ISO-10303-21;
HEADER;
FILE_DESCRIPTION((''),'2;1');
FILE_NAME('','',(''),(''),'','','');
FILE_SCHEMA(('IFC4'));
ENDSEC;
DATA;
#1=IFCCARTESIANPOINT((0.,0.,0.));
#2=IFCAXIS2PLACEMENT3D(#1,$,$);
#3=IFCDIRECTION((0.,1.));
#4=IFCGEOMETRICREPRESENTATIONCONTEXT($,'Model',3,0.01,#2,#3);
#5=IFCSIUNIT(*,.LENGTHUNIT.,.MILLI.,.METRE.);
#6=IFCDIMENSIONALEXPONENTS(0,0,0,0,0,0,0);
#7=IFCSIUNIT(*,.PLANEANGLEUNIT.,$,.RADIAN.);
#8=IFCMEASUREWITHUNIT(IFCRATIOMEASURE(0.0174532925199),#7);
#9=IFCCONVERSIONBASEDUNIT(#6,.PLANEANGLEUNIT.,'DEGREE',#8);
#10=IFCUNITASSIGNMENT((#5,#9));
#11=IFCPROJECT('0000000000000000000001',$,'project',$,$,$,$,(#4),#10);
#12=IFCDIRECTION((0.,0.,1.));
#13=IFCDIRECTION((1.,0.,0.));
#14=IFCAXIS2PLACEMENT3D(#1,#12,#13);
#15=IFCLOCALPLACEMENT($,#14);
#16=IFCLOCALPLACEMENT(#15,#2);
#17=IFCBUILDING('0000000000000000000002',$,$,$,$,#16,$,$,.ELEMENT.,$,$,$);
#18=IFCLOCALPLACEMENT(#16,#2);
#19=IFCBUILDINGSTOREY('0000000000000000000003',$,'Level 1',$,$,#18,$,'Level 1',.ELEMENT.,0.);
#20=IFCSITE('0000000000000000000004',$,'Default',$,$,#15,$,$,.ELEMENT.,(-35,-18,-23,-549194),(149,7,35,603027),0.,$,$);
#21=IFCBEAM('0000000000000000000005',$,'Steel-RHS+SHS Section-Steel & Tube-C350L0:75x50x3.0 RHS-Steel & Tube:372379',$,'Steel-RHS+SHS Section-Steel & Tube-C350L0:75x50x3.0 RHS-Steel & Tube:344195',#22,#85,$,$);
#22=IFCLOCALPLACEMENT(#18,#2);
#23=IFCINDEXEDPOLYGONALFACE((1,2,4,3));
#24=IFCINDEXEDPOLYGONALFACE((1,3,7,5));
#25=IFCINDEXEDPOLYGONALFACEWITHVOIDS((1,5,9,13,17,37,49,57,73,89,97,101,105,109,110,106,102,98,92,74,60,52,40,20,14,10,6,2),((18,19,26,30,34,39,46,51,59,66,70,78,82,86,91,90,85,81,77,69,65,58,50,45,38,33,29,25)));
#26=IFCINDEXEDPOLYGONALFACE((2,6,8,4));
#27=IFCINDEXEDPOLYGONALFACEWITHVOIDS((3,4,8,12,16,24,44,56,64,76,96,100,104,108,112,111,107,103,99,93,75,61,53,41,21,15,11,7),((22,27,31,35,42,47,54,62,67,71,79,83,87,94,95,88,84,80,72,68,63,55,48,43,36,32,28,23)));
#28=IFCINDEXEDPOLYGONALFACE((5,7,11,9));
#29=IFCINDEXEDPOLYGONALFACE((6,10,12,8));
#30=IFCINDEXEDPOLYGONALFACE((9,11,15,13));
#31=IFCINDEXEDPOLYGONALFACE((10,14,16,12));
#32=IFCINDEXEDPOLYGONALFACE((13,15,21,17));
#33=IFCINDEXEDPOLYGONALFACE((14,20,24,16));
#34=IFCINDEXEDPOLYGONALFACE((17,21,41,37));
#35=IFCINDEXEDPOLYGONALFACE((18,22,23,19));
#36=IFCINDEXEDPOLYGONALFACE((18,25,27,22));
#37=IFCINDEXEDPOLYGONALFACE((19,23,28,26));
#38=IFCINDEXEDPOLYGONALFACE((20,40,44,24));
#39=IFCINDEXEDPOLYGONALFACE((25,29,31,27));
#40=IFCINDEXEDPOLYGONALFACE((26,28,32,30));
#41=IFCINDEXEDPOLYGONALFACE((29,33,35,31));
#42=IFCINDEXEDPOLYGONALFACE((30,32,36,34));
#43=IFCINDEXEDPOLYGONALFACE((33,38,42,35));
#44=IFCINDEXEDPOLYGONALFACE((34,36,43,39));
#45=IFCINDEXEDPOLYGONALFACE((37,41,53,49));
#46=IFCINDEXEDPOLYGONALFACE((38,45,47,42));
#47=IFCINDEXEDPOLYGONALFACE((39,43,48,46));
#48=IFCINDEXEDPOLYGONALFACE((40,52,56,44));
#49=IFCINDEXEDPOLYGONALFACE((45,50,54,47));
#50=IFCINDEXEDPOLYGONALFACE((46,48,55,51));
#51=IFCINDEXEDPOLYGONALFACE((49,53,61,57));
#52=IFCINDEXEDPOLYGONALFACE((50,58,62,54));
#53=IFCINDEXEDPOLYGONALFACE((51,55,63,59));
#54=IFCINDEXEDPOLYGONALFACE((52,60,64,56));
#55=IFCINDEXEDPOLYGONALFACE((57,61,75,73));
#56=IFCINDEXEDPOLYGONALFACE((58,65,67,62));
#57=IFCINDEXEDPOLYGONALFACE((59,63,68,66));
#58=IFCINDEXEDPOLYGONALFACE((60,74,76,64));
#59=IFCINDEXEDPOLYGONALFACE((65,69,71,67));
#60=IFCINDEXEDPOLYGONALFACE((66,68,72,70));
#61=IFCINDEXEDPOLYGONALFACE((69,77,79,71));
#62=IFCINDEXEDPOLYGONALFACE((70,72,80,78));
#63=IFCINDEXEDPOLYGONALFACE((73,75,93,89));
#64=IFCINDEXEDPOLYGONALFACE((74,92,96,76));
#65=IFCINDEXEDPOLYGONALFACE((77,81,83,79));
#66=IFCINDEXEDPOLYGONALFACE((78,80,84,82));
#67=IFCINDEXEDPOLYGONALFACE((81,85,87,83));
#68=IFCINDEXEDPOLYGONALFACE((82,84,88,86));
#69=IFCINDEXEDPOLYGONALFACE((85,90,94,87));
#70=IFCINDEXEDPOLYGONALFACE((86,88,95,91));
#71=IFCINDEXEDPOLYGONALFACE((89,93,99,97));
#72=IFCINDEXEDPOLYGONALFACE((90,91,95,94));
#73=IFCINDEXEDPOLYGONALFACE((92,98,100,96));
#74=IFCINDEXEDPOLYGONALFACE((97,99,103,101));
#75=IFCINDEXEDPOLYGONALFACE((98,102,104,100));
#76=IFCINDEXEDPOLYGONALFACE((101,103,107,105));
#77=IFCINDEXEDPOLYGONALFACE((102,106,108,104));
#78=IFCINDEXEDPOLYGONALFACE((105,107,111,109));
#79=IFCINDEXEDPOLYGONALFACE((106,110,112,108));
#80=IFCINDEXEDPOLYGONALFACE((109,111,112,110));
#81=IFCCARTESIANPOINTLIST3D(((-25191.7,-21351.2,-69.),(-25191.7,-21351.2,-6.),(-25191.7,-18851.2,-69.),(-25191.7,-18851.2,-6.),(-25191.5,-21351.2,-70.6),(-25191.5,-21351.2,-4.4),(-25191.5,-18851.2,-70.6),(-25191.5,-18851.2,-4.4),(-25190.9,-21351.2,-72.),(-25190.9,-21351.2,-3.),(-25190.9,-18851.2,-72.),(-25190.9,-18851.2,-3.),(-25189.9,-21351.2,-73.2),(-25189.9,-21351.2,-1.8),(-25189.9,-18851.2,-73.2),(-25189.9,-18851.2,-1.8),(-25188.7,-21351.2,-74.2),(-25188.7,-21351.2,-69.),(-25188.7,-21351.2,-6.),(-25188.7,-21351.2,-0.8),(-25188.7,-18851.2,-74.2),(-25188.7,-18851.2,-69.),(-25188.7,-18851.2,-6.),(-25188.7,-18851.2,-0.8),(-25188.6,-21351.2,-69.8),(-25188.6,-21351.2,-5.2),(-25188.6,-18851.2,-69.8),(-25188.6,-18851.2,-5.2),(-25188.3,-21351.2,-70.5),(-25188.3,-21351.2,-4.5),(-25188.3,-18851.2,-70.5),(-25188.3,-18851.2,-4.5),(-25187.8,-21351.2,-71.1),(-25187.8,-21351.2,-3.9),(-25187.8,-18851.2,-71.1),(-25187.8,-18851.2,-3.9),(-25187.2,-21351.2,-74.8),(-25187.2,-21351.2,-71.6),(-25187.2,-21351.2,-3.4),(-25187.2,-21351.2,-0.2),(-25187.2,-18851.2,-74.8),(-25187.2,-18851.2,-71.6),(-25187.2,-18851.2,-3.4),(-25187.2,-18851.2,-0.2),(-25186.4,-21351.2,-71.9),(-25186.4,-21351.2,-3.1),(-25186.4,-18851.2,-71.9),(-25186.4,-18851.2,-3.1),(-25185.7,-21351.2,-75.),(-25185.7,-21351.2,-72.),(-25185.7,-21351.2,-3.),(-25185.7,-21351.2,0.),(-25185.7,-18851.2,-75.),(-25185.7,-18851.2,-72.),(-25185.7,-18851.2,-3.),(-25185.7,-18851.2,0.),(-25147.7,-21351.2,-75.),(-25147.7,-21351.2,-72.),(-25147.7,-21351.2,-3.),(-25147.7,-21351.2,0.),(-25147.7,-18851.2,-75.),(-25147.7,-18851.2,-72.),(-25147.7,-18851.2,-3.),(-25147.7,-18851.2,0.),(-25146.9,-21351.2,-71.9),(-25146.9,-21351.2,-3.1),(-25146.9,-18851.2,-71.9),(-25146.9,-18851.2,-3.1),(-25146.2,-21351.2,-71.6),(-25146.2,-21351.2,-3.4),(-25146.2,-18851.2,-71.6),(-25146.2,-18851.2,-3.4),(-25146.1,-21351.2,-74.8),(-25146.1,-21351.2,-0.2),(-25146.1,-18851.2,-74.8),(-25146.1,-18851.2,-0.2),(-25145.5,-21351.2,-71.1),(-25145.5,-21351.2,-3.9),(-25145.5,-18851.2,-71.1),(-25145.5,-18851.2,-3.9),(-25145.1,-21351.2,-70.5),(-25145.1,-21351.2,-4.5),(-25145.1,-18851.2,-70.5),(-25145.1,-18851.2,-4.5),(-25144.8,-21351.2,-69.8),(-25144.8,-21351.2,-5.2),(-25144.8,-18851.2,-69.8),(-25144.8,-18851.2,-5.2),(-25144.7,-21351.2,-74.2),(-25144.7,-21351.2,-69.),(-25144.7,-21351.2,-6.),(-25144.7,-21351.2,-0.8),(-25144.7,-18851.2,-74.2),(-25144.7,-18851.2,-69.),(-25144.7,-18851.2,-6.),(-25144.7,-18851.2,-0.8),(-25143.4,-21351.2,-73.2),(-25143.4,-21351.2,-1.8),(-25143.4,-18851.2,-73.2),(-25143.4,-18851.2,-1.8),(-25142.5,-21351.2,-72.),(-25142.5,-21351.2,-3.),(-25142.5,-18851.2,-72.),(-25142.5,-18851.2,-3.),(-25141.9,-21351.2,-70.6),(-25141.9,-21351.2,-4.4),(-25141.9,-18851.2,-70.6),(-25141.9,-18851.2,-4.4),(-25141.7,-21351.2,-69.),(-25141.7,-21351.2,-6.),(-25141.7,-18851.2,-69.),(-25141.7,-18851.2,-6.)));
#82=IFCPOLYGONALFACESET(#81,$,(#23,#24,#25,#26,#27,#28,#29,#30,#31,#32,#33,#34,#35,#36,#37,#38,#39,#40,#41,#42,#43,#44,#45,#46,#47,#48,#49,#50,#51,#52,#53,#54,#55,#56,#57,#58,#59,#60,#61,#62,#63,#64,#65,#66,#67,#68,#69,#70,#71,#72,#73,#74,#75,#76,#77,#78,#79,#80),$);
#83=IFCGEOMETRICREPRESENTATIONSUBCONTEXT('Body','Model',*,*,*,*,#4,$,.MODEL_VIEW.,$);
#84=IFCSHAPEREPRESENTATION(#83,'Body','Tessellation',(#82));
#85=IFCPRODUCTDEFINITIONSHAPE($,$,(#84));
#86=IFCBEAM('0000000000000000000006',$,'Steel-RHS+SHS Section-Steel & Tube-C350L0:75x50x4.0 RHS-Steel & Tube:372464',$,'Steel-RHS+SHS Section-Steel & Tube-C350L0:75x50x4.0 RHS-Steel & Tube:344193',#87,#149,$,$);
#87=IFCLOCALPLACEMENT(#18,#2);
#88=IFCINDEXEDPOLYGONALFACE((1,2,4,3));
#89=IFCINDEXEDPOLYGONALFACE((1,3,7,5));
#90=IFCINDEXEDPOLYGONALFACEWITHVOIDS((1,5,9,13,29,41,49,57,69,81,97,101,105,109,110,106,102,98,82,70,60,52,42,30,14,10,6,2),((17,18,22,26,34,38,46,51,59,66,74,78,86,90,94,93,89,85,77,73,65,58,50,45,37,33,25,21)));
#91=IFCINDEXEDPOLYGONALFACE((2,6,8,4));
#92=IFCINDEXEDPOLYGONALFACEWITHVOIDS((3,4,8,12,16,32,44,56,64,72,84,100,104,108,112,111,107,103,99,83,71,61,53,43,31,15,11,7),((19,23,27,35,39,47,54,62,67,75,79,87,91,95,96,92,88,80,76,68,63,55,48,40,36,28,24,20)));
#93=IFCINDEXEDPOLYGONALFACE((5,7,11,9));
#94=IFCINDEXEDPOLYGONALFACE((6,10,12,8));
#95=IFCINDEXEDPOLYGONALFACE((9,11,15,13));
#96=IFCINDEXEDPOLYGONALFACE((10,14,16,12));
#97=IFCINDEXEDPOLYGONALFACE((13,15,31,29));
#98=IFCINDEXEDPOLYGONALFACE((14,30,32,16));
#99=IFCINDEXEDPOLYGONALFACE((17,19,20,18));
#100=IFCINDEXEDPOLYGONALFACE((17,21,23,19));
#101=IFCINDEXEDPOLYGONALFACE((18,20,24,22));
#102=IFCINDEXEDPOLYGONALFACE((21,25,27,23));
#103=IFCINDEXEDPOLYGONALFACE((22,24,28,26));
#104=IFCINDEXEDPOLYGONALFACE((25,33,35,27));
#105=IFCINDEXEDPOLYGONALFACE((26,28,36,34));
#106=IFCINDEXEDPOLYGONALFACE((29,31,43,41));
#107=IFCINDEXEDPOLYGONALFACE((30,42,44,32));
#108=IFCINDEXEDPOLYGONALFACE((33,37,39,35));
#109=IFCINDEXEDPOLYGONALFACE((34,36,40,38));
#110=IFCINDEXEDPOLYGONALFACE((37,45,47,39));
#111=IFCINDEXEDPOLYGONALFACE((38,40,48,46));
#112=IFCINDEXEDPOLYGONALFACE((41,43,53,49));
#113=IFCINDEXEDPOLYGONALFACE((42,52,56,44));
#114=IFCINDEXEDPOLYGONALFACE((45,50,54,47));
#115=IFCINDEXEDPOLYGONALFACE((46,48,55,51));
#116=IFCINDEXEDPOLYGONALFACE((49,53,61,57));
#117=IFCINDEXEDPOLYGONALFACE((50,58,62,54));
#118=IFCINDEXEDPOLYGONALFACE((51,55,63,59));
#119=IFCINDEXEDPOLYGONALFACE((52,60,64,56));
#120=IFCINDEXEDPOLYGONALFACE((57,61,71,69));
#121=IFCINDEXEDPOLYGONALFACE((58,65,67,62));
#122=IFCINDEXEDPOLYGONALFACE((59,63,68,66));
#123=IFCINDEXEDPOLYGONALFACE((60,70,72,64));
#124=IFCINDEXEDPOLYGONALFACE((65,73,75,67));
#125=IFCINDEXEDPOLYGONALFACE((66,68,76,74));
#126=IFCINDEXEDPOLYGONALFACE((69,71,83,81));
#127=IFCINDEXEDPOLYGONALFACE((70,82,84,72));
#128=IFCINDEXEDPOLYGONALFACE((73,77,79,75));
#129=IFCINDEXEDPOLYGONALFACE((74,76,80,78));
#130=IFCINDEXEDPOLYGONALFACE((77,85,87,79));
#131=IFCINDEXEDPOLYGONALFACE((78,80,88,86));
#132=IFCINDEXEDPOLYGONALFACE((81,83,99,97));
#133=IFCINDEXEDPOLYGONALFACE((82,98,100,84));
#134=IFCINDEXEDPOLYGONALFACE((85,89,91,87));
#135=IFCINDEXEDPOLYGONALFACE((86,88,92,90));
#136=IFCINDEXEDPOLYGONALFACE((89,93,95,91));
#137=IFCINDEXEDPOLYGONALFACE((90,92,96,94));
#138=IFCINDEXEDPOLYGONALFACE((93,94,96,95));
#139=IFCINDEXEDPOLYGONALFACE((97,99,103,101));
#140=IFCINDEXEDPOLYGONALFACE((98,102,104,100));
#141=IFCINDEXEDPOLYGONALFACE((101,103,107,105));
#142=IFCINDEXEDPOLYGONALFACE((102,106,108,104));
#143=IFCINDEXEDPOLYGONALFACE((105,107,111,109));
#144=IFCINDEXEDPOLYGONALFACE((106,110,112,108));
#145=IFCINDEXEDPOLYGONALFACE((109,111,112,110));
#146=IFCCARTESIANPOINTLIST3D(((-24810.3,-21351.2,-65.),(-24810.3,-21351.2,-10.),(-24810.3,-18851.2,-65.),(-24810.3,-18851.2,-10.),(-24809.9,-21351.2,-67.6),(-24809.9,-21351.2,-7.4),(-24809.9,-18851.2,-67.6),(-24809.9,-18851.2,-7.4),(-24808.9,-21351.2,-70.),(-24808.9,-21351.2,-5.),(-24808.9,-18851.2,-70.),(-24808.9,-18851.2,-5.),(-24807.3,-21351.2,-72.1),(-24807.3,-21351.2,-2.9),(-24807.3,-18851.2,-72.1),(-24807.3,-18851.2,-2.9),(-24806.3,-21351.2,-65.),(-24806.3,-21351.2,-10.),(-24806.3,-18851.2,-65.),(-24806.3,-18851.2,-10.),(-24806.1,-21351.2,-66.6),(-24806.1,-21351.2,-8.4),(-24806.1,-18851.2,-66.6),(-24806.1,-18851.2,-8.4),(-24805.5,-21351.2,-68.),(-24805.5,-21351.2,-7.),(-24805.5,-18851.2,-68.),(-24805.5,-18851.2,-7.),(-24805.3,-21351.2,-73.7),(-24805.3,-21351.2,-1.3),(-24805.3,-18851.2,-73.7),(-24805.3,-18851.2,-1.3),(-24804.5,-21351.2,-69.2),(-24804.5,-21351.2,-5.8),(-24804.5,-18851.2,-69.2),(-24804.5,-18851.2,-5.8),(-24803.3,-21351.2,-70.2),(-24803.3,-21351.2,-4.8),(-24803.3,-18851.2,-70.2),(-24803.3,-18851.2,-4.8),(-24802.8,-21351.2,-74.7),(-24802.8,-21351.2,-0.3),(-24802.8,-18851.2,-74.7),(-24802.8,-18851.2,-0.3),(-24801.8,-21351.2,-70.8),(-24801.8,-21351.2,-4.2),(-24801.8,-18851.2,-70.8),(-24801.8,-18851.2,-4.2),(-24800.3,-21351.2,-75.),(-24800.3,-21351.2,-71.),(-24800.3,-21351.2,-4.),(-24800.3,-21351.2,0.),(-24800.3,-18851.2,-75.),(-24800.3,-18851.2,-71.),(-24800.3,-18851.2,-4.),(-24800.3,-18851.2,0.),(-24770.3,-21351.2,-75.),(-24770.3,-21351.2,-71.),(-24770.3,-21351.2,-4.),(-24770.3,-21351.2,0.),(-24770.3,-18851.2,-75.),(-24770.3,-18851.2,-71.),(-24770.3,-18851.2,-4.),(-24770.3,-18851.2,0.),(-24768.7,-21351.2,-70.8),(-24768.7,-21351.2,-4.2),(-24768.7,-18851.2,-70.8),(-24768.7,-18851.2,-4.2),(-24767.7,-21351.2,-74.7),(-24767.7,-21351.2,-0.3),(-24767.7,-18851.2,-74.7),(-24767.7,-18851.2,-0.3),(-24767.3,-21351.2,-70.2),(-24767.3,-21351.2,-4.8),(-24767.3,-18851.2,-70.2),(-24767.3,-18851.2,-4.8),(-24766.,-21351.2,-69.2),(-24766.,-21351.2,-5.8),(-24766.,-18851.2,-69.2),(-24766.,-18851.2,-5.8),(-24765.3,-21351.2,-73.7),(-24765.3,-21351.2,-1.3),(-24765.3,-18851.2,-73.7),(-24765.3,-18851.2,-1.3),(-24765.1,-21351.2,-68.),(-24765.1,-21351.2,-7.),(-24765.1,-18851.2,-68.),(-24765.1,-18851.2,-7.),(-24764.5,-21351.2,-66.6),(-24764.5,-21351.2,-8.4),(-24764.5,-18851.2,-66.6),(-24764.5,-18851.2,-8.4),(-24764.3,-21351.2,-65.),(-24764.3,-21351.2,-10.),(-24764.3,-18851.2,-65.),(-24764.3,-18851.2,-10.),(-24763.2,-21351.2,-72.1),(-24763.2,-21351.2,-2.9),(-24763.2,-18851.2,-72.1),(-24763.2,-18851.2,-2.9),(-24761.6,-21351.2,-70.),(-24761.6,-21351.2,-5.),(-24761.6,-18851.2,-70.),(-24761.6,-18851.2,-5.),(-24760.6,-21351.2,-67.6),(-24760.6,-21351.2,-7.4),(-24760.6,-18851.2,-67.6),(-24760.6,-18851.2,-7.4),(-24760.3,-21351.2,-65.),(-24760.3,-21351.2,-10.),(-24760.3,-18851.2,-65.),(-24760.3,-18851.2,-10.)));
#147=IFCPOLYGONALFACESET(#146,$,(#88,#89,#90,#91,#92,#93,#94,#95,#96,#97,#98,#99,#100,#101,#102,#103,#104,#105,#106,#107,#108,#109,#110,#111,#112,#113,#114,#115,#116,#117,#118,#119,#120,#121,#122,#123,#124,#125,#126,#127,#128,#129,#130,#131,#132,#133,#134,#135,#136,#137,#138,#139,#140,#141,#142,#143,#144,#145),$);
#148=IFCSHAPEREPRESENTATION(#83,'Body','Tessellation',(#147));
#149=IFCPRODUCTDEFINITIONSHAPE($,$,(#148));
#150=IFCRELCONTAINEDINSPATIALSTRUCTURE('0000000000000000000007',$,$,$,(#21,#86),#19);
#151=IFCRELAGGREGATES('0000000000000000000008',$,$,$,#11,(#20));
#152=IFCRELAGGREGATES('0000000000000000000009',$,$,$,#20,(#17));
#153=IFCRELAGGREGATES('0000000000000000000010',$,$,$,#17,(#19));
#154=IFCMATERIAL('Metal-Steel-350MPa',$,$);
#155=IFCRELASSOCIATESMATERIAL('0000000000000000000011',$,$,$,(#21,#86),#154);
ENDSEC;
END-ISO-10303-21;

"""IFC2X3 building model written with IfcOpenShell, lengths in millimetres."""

from ifc_helpers import new_model, entity, si_unit, converted_unit, direction, frame, frame_2d, origin, origin_with_axes, place, context, subcontext, project, spatial, polyline, circle_curve, parameter, trimmed, segment, composite_curve, outline, extrude, material, element, save


model = new_model("IFC2X3")

# Units and contexts
model_context = context("Model", 3, precision=0.01, world=origin(), true_north=direction((0.0, 1.0)))
body_context = subcontext(model_context, "Body", "Model", "MODEL_VIEW")
ifc_project = project(units=[si_unit("LENGTHUNIT", "METRE", prefix="MILLI"), converted_unit("PLANEANGLEUNIT", "DEGREE", entity("IfcRatioMeasure", 0.0174532925199), si_unit("PLANEANGLEUNIT", "RADIAN"), dimensions=[0, 0, 0, 0, 0, 0, 0])], contexts=[model_context])

# Site, building, storey
site_placement = place(None, origin_with_axes())
site = spatial("IfcSite", under=ifc_project, at=site_placement, Name="Default", CompositionType="ELEMENT", RefLatitude=(-35, -18, -23, -549194), RefLongitude=(149, 7, 35, 603027), RefElevation=0.0)
building_placement = place(site_placement, origin())
building = spatial("IfcBuilding", under=site, at=building_placement, CompositionType="ELEMENT")
storey_placement = place(building_placement, origin())
storey = spatial("IfcBuildingStorey", under=building, at=storey_placement, Name="Level 1", LongName="Level 1", CompositionType="ELEMENT", Elevation=0.0)

# Beams
ifc_material = material(Name="Metal-Steel-350MPa")
beam_1_placement = place(storey_placement, frame((-25166.7, -18851.2, 0.0), z_axis=(0.0, 0.0, 1.0), x_axis=(0.0, -1.0, 0.0)))
element("IfcBeam", 1, at=beam_1_placement, inside=storey, material=ifc_material, Name="Steel-RHS+SHS Section-Steel & Tube-C350L0:75x50x3.0 RHS-Steel & Tube:372379", ObjectType="Steel-RHS+SHS Section-Steel & Tube-C350L0:75x50x3.0 RHS-Steel & Tube:344195", context=body_context, shape_type="SweptSolid", body=[
    extrude(outline(composite_curve([segment(trimmed(circle_curve(frame_2d((-19.0, -31.5), x_axis=(1.0, 0.0)), 6.0), [parameter(180.0)], [parameter(270.0)], True, "PARAMETER"), True, "CONTINUOUS"), segment(polyline([(-19.0, -37.5), (19.0, -37.5)]), True, "CONTINUOUS"), segment(trimmed(circle_curve(frame_2d((19.0, -31.5), x_axis=(1.0, 0.0)), 6.0), [parameter(270.0)], [parameter(0.0)], True, "PARAMETER"), True, "CONTINUOUS"), segment(polyline([(25.0, -31.5), (25.0, 31.5)]), True, "CONTINUOUS"), segment(trimmed(circle_curve(frame_2d((19.0, 31.5), x_axis=(1.0, 0.0)), 6.0), [parameter(0.0)], [parameter(90.0)], True, "PARAMETER"), True, "CONTINUOUS"), segment(polyline([(19.0, 37.5), (-19.0, 37.5)]), True, "CONTINUOUS"), segment(trimmed(circle_curve(frame_2d((-19.0, 31.5), x_axis=(1.0, 0.0)), 6.0), [parameter(90.0)], [parameter(180.0)], True, "PARAMETER"), True, "CONTINUOUS"), segment(polyline([(-25.0, 31.5), (-25.0, -31.5)]), True, "CONTINUOUS")], self_intersect=False), holes=[composite_curve([segment(polyline([(19.0, -34.5), (-19.0, -34.5)]), True, "CONTINUOUS"), segment(trimmed(circle_curve(frame_2d((-19.0, -31.5), x_axis=(1.0, 0.0)), 3.0), [parameter(180.0)], [parameter(270.0)], True, "PARAMETER"), False, "CONTINUOUS"), segment(polyline([(-22.0, -31.5), (-22.0, 31.5)]), True, "CONTINUOUS"), segment(trimmed(circle_curve(frame_2d((-19.0, 31.5), x_axis=(1.0, 0.0)), 3.0), [parameter(90.0)], [parameter(180.0)], True, "PARAMETER"), False, "CONTINUOUS"), segment(polyline([(-19.0, 34.5), (19.0, 34.5)]), True, "CONTINUOUS"), segment(trimmed(circle_curve(frame_2d((19.0, 31.5), x_axis=(1.0, 0.0)), 3.0), [parameter(360.0)], [parameter(90.0)], True, "PARAMETER"), False, "CONTINUOUS"), segment(polyline([(22.0, 31.5), (22.0, -31.5)]), True, "CONTINUOUS"), segment(trimmed(circle_curve(frame_2d((19.0, -31.5), x_axis=(1.0, 0.0)), 3.0), [parameter(270.0)], [parameter(0.0)], True, "PARAMETER"), False, "CONTINUOUS")], self_intersect=False)]), frame((0.0, 0.0, -37.5), z_axis=(1.0, 0.0, 0.0), x_axis=(0.0, -1.0, 0.0)), (0.0, 0.0, 1.0), 2500.0),
])
beam_2_placement = place(storey_placement, frame((-24785.3, -18851.2, 0.0), z_axis=(0.0, 0.0, 1.0), x_axis=(0.0, -1.0, 0.0)))
element("IfcBeam", 2, at=beam_2_placement, inside=storey, material=ifc_material, Name="Steel-RHS+SHS Section-Steel & Tube-C350L0:75x50x4.0 RHS-Steel & Tube:372464", ObjectType="Steel-RHS+SHS Section-Steel & Tube-C350L0:75x50x4.0 RHS-Steel & Tube:344193", context=body_context, shape_type="SweptSolid", body=[
    extrude(outline(composite_curve([segment(trimmed(circle_curve(frame_2d((-15.0, -27.5), x_axis=(1.0, 0.0)), 10.0), [parameter(180.0)], [parameter(270.0)], True, "PARAMETER"), True, "CONTINUOUS"), segment(polyline([(-15.0, -37.5), (15.0, -37.5)]), True, "CONTINUOUS"), segment(trimmed(circle_curve(frame_2d((15.0, -27.5), x_axis=(1.0, 0.0)), 10.0), [parameter(270.0)], [parameter(0.0)], True, "PARAMETER"), True, "CONTINUOUS"), segment(polyline([(25.0, -27.5), (25.0, 27.5)]), True, "CONTINUOUS"), segment(trimmed(circle_curve(frame_2d((15.0, 27.5), x_axis=(1.0, 0.0)), 10.0), [parameter(0.0)], [parameter(90.0)], True, "PARAMETER"), True, "CONTINUOUS"), segment(polyline([(15.0, 37.5), (-15.0, 37.5)]), True, "CONTINUOUS"), segment(trimmed(circle_curve(frame_2d((-15.0, 27.5), x_axis=(1.0, 0.0)), 10.0), [parameter(90.0)], [parameter(180.0)], True, "PARAMETER"), True, "CONTINUOUS"), segment(polyline([(-25.0, 27.5), (-25.0, -27.5)]), True, "CONTINUOUS")], self_intersect=False), holes=[composite_curve([segment(polyline([(15.0, -33.5), (-15.0, -33.5)]), True, "CONTINUOUS"), segment(trimmed(circle_curve(frame_2d((-15.0, -27.5), x_axis=(1.0, 0.0)), 6.0), [parameter(180.0)], [parameter(270.0)], True, "PARAMETER"), False, "CONTINUOUS"), segment(polyline([(-21.0, -27.5), (-21.0, 27.5)]), True, "CONTINUOUS"), segment(trimmed(circle_curve(frame_2d((-15.0, 27.5), x_axis=(1.0, 0.0)), 6.0), [parameter(90.0)], [parameter(180.0)], True, "PARAMETER"), False, "CONTINUOUS"), segment(polyline([(-15.0, 33.5), (15.0, 33.5)]), True, "CONTINUOUS"), segment(trimmed(circle_curve(frame_2d((15.0, 27.5), x_axis=(1.0, 0.0)), 6.0), [parameter(360.0)], [parameter(90.0)], True, "PARAMETER"), False, "CONTINUOUS"), segment(polyline([(21.0, 27.5), (21.0, -27.5)]), True, "CONTINUOUS"), segment(trimmed(circle_curve(frame_2d((15.0, -27.5), x_axis=(1.0, 0.0)), 6.0), [parameter(270.0)], [parameter(0.0)], True, "PARAMETER"), False, "CONTINUOUS")], self_intersect=False)]), frame((0.0, 0.0, -37.5), z_axis=(1.0, 0.0, 0.0), x_axis=(0.0, -1.0, 0.0)), (0.0, 0.0, 1.0), 2500.0),
])

save(model, "model.ifc")
